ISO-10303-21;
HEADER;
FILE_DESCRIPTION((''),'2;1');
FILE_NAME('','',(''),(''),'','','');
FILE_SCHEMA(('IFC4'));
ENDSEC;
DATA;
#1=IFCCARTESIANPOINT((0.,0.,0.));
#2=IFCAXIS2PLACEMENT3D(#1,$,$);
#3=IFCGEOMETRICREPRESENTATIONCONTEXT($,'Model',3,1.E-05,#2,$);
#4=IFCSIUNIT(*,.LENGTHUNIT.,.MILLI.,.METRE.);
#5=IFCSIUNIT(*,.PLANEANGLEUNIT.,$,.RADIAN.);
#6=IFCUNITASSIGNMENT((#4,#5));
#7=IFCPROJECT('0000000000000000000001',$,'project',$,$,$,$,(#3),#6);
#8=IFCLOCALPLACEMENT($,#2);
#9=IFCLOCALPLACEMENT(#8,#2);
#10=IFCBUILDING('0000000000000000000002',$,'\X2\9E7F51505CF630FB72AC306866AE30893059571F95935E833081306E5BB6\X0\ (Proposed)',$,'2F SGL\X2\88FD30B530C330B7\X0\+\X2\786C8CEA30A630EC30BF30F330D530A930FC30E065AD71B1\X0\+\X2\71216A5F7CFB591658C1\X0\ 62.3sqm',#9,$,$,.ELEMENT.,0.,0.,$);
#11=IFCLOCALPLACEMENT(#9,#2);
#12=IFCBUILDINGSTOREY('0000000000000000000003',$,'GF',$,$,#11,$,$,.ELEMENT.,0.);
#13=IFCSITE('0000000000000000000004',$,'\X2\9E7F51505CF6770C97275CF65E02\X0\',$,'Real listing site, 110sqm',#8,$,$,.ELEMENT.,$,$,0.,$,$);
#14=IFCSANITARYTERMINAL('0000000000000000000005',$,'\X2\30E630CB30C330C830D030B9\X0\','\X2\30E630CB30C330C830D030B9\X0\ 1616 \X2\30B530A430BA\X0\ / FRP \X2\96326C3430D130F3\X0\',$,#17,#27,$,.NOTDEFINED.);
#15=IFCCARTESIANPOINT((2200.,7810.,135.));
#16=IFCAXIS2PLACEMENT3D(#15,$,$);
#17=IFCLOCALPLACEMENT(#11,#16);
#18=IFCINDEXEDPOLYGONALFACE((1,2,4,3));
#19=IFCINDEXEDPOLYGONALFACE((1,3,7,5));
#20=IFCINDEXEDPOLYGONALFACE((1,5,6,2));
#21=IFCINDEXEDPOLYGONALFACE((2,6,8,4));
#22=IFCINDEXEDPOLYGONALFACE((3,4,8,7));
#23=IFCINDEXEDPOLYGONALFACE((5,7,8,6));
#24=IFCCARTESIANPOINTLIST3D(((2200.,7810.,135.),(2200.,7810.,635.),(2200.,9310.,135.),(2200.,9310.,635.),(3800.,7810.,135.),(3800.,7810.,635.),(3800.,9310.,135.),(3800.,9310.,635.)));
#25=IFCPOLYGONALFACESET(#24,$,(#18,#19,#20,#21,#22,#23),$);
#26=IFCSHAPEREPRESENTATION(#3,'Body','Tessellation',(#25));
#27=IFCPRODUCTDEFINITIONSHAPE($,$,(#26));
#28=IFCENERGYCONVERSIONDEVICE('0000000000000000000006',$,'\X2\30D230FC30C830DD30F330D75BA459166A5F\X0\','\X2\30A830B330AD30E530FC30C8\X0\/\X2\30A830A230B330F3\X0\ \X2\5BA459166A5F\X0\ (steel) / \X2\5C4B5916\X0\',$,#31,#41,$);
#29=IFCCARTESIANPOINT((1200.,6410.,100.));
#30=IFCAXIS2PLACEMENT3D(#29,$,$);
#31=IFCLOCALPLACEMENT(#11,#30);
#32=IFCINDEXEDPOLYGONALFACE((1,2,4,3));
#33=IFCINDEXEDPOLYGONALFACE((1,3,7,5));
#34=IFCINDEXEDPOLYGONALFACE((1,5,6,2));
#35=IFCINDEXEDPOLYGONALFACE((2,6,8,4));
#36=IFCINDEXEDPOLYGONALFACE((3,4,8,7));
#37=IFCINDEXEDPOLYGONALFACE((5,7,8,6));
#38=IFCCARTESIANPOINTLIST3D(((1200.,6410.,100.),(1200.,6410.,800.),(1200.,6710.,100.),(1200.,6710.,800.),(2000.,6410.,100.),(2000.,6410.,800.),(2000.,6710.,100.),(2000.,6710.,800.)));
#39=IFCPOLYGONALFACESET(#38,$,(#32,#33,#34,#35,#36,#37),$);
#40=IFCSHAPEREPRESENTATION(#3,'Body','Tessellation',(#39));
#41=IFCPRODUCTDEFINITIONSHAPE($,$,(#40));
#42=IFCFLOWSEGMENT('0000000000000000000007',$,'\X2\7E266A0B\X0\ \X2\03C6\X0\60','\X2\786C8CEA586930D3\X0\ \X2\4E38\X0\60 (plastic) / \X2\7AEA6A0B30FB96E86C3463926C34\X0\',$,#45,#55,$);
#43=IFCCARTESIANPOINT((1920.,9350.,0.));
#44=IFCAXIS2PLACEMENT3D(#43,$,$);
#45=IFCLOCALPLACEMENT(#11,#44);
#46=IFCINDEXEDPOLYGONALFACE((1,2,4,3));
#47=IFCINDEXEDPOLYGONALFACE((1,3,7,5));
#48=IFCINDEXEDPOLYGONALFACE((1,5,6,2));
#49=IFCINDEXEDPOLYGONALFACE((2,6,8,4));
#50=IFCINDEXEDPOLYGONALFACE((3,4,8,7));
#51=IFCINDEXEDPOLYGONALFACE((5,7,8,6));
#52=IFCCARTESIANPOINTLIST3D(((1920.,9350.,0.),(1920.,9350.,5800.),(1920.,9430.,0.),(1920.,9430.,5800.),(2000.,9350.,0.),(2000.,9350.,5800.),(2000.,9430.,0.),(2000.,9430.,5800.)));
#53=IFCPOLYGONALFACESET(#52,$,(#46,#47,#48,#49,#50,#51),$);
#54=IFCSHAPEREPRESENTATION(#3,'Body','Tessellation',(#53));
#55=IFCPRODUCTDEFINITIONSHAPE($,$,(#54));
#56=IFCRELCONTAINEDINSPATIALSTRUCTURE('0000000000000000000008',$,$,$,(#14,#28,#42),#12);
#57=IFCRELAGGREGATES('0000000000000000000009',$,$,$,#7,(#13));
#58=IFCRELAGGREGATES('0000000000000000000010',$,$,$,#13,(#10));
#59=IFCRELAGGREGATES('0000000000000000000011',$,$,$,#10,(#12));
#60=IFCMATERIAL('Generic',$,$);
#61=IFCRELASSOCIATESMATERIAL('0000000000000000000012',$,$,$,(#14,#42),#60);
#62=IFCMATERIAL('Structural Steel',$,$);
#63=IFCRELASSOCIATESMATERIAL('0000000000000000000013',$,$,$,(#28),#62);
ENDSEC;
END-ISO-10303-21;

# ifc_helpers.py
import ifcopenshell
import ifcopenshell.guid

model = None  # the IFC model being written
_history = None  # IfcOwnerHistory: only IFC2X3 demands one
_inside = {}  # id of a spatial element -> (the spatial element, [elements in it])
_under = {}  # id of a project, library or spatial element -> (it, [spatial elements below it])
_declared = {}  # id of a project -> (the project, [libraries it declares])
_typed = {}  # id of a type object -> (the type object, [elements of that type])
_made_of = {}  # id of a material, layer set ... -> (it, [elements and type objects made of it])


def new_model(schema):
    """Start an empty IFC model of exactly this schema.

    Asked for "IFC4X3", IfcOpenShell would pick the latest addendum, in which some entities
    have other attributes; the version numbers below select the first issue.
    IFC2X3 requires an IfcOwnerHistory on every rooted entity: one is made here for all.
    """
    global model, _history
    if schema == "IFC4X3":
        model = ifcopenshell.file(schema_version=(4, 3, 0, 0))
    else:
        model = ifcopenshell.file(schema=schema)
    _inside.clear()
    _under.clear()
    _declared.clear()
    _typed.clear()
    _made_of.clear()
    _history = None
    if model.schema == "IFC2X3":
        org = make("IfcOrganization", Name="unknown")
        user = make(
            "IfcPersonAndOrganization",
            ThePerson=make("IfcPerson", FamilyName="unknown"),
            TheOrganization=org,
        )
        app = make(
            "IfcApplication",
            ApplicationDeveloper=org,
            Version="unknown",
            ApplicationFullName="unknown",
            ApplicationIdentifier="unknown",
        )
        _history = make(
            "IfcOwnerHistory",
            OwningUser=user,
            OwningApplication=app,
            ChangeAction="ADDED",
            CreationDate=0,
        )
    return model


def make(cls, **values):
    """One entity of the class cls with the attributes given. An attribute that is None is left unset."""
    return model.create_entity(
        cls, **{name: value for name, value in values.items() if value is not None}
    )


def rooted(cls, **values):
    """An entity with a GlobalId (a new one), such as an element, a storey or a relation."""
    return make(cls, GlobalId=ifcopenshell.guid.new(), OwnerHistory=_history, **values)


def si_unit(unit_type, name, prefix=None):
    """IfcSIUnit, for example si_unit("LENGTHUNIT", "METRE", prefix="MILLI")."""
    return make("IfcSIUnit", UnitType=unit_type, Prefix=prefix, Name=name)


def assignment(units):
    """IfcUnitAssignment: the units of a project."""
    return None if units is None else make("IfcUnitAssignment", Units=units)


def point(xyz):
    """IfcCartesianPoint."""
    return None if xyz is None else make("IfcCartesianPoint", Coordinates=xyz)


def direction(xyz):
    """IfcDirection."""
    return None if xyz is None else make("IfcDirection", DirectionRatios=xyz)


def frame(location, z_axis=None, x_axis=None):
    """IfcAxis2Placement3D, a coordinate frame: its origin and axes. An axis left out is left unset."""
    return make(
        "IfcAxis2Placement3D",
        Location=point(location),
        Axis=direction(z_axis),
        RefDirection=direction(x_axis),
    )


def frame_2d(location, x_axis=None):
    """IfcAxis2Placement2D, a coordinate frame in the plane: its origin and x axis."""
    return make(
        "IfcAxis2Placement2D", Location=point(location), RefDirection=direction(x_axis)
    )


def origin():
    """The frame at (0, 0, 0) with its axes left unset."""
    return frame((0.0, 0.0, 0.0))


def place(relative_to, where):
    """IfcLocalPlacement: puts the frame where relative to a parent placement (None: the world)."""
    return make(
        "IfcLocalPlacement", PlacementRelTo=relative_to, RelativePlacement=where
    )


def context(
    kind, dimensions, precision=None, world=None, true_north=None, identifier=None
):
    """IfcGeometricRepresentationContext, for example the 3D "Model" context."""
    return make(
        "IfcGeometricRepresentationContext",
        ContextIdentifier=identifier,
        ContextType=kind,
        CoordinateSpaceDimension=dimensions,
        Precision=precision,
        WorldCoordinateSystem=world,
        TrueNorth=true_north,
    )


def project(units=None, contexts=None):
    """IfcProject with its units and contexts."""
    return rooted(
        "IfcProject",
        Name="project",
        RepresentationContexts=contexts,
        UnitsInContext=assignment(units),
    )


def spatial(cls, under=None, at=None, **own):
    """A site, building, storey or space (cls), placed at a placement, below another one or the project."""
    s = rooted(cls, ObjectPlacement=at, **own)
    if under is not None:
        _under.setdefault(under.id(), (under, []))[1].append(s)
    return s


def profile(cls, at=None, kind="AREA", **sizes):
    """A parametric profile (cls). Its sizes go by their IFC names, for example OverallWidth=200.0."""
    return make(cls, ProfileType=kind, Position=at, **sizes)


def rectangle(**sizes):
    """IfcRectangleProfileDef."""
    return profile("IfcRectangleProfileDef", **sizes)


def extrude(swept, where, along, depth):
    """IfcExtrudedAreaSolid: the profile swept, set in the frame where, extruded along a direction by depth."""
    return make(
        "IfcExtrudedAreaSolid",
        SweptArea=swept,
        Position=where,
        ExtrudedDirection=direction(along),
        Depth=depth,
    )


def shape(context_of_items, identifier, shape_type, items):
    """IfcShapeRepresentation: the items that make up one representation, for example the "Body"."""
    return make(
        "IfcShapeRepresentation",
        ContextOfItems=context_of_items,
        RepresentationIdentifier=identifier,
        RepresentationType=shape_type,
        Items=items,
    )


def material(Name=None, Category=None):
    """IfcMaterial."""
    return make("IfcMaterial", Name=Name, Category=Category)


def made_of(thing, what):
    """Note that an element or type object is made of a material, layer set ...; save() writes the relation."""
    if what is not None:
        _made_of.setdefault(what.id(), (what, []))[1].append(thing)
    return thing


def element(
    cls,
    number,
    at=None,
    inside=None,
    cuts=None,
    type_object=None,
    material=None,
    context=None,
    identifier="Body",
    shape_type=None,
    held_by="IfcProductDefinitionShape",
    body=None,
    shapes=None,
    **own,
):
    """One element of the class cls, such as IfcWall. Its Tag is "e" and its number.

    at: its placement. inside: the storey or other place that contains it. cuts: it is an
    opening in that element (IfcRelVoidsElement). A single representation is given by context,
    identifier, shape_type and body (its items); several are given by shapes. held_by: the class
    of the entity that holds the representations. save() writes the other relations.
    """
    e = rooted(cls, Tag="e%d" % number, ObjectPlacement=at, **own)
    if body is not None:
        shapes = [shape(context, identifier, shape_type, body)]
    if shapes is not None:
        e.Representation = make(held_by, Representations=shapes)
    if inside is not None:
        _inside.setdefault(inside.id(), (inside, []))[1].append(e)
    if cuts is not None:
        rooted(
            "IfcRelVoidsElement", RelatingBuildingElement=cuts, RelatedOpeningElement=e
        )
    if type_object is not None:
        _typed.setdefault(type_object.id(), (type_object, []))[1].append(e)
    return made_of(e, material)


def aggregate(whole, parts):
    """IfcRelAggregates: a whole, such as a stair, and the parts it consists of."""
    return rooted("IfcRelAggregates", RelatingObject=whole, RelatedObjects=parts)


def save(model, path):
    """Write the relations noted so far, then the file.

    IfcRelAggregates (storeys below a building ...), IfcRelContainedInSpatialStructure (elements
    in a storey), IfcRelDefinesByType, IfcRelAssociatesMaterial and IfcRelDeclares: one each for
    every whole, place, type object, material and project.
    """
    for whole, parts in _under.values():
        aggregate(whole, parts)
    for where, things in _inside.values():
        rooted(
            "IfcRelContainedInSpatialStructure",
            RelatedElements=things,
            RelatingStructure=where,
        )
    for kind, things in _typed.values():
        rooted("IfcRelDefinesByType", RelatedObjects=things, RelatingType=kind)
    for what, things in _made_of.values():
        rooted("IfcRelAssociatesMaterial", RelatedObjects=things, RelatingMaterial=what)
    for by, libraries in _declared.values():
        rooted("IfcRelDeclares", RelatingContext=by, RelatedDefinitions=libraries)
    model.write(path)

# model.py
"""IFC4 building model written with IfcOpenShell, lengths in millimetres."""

from ifc_helpers import new_model, si_unit, frame, frame_2d, origin, place, context, project, spatial, rectangle, extrude, material, element, save


model = new_model("IFC4")

# Units and contexts
model_context = context("Model", 3, precision=1e-05, world=origin())
ifc_project = project(units=[si_unit("LENGTHUNIT", "METRE", prefix="MILLI"), si_unit("PLANEANGLEUNIT", "RADIAN")], contexts=[model_context])

# Site, building, storey
site_placement = place(None, origin())
site = spatial("IfcSite", under=ifc_project, at=site_placement, Name="鹿児島県霧島市", ObjectType="Real listing site, 110sqm", CompositionType="ELEMENT", RefElevation=0.0)
building_placement = place(site_placement, origin())
building = spatial("IfcBuilding", under=site, at=building_placement, Name="鹿児島・犬と暮らす土間広めの家 (Proposed)", ObjectType="2F SGL製サッシ+硬質ウレタンフォーム断熱+無機系外壁 62.3sqm", CompositionType="ELEMENT", ElevationOfRefHeight=0.0, ElevationOfTerrain=0.0)
storey_placement = place(building_placement, origin())
storey = spatial("IfcBuildingStorey", under=building, at=storey_placement, Name="GF", CompositionType="ELEMENT", Elevation=0.0)

# Shared definitions
ifc_material_1 = material(Name="Generic")

# Sanitary terminal
sanitary_terminal_placement = place(storey_placement, frame((2200.0, 7810.0, 135.0)))
element("IfcSanitaryTerminal", 1, at=sanitary_terminal_placement, inside=storey, material=ifc_material_1, Name="ユニットバス", Description="ユニットバス 1616 サイズ / FRP 防水パン", PredefinedType="NOTDEFINED", context=model_context, shape_type="SweptSolid", body=[
    extrude(rectangle(XDim=1600.0, YDim=1500.0, at=frame_2d((800.0, 750.0))), frame((2200.0, 7810.0, 135.0)), (0.0, 0.0, 1.0), 500.0),
])

# Energy conversion device
ifc_material_2 = material(Name="Structural Steel")
energy_conversion_device_placement = place(storey_placement, frame((1200.0, 6410.0, 100.0)))
element("IfcEnergyConversionDevice", 2, at=energy_conversion_device_placement, inside=storey, material=ifc_material_2, Name="ヒートポンプ室外機", Description="エコキュート/エアコン 室外機 (steel) / 屋外", context=model_context, shape_type="SweptSolid", body=[
    extrude(rectangle(XDim=800.0, YDim=300.0, at=frame_2d((400.0, 150.0))), frame((1200.0, 6410.0, 100.0)), (0.0, 0.0, 1.0), 700.0),
])

# Flow segment
flow_segment_placement = place(storey_placement, frame((1920.0, 9350.0, 0.0)))
element("IfcFlowSegment", 3, at=flow_segment_placement, inside=storey, material=ifc_material_1, Name="縦樋 φ60", Description="硬質塩ビ 丸60 (plastic) / 竪樋・雨水排水", context=model_context, shape_type="SweptSolid", body=[
    extrude(rectangle(XDim=80.0, YDim=80.0, at=frame_2d((40.0, 40.0))), frame((1920.0, 9350.0, 0.0)), (0.0, 0.0, 1.0), 5800.0),
])

save(model, "model.ifc")
